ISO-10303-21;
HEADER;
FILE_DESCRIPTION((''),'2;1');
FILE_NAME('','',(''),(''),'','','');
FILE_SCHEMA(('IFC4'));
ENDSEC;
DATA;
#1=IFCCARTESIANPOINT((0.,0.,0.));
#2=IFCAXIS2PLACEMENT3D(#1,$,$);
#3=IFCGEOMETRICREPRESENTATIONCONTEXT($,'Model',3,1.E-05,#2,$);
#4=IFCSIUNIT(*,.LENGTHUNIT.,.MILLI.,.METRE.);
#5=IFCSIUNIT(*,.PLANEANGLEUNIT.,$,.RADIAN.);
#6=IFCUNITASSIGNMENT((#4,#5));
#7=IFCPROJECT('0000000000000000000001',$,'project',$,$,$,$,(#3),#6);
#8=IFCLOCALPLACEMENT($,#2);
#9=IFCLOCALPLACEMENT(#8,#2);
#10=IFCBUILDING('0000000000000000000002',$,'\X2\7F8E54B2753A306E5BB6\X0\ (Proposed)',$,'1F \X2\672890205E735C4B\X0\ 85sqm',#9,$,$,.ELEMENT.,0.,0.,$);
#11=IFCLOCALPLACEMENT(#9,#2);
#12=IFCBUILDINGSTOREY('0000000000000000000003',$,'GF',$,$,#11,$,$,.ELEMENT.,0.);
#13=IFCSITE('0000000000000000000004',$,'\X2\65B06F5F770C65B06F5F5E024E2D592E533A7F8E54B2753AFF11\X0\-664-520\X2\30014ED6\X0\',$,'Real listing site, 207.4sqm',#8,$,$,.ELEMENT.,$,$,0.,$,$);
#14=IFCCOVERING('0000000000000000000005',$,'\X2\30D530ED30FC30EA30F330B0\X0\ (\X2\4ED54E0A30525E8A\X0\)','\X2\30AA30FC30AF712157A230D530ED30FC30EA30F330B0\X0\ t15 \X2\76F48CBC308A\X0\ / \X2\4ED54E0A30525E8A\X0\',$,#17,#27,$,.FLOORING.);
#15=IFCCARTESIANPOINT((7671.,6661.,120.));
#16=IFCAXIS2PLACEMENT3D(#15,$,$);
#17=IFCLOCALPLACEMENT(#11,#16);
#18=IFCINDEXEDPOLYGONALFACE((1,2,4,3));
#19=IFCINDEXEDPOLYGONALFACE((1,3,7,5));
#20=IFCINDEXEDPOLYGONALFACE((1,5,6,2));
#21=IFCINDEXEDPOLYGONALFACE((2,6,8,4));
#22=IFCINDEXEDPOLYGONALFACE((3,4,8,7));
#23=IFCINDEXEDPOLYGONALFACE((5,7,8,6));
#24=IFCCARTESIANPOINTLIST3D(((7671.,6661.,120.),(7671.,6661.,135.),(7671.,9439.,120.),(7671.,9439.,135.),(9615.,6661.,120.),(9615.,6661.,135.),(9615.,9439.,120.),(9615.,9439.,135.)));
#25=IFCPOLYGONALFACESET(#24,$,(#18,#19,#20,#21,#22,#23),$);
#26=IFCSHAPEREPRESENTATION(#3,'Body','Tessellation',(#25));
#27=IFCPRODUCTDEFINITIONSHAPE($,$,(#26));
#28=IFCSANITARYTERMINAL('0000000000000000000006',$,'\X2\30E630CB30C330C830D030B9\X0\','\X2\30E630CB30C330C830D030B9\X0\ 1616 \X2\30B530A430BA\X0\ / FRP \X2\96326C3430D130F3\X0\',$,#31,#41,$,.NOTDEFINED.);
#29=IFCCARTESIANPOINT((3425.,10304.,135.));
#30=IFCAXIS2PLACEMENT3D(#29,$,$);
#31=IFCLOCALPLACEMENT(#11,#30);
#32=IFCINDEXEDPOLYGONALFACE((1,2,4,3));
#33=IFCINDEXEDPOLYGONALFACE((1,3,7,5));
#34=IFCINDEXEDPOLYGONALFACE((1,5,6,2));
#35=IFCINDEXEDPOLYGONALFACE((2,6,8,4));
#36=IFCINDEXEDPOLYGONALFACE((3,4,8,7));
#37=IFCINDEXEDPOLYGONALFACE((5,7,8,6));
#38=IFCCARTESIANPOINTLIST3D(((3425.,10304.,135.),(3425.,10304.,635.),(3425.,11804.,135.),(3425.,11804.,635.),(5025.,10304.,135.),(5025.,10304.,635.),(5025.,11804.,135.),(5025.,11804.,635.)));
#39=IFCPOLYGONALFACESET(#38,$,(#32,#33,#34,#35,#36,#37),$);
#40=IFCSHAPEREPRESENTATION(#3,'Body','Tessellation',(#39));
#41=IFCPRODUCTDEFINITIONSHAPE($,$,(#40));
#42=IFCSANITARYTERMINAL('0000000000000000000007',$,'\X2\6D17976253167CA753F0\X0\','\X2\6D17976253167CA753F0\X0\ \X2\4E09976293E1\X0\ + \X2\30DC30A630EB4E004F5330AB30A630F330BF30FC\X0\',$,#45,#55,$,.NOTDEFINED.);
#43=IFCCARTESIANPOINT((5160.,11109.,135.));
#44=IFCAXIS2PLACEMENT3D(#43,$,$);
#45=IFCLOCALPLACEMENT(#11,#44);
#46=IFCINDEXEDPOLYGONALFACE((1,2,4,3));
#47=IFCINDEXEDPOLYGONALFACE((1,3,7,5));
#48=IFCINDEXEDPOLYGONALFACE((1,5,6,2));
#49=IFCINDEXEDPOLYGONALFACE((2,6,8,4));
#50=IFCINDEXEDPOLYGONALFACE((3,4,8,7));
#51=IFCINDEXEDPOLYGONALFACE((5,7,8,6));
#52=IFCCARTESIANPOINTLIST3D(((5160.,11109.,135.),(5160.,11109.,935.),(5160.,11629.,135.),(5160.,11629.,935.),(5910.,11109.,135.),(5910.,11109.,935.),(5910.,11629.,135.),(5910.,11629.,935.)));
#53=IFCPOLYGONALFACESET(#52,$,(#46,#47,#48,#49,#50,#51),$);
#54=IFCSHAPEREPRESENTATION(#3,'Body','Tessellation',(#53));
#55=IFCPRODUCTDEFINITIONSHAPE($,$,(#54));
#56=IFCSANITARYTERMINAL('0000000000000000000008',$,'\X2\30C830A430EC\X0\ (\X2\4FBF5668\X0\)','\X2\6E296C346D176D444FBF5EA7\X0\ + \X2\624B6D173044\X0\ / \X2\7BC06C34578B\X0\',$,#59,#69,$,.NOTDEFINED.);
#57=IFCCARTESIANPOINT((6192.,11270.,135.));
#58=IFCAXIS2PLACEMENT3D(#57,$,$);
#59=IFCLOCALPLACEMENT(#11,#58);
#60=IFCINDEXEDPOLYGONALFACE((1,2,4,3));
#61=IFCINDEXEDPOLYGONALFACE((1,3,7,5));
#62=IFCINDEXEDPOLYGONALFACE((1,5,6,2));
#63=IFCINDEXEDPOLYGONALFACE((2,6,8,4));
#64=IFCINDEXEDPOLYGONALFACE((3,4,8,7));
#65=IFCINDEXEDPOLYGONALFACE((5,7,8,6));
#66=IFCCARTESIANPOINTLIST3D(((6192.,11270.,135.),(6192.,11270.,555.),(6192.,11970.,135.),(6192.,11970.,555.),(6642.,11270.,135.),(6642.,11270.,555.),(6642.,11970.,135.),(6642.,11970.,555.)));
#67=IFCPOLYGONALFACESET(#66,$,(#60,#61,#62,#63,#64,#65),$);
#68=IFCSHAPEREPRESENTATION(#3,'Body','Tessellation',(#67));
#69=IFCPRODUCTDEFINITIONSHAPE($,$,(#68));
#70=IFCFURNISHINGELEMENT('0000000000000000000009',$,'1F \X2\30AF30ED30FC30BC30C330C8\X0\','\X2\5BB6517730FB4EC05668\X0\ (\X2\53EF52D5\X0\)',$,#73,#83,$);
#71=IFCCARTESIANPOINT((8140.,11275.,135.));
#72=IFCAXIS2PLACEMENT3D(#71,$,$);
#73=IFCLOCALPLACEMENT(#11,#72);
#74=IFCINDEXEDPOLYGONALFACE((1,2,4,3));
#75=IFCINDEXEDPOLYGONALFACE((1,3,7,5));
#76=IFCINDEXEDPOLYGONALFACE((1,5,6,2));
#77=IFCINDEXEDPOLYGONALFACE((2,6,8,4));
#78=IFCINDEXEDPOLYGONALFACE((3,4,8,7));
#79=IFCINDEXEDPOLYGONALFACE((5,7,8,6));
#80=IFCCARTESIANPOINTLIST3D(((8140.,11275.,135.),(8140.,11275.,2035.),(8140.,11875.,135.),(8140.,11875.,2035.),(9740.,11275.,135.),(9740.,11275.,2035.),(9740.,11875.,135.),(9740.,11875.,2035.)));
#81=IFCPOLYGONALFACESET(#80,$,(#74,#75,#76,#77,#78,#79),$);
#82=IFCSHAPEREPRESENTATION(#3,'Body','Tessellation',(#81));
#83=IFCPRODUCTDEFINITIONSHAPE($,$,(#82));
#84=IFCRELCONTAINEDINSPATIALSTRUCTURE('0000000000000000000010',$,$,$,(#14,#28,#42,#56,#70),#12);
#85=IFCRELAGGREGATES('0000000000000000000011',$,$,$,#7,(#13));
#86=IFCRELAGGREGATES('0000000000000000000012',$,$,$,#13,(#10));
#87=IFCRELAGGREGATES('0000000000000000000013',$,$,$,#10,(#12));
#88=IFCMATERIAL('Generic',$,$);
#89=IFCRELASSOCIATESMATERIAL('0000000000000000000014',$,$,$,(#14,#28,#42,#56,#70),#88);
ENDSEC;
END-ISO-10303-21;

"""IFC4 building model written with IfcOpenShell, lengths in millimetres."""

from ifc_helpers import new_model, si_unit, frame, frame_2d, origin, place, context, project, spatial, rectangle, extrude, material, element, save


model = new_model("IFC4")

# Units and contexts
model_context = context("Model", 3, precision=1e-05, world=origin())
ifc_project = project(units=[si_unit("LENGTHUNIT", "METRE", prefix="MILLI"), si_unit("PLANEANGLEUNIT", "RADIAN")], contexts=[model_context])

# Site, building, storey
site_placement = place(None, origin())
site = spatial("IfcSite", under=ifc_project, at=site_placement, Name="新潟県新潟市中央区美咲町１-664-520、他", ObjectType="Real listing site, 207.4sqm", CompositionType="ELEMENT", RefElevation=0.0)
building_placement = place(site_placement, origin())
building = spatial("IfcBuilding", under=site, at=building_placement, Name="美咲町の家 (Proposed)", ObjectType="1F 木造平屋 85sqm", CompositionType="ELEMENT", ElevationOfRefHeight=0.0, ElevationOfTerrain=0.0)
storey_placement = place(building_placement, origin())
storey = spatial("IfcBuildingStorey", under=building, at=storey_placement, Name="GF", CompositionType="ELEMENT", Elevation=0.0)

# Covering
ifc_material_1 = material(Name="Generic")
covering_1_placement = place(storey_placement, frame((7671.0, 6661.0, 120.0)))
element("IfcCovering", 1, at=covering_1_placement, inside=storey, material=ifc_material_1, Name="フローリング (仕上げ床)", Description="オーク無垢フローリング t15 直貼り / 仕上げ床", PredefinedType="FLOORING", context=model_context, shape_type="SweptSolid", body=[
    extrude(rectangle(XDim=1944.0, YDim=2778.0, at=frame_2d((972.0, 1389.0))), frame((7671.0, 6661.0, 120.0)), (0.0, 0.0, 1.0), 15.0),
])

# Sanitary terminals
sanitary_terminal_1_placement = place(storey_placement, frame((3425.0, 10304.0, 135.0)))
element("IfcSanitaryTerminal", 2, at=sanitary_terminal_1_placement, inside=storey, material=ifc_material_1, Name="ユニットバス", Description="ユニットバス 1616 サイズ / FRP 防水パン", PredefinedType="NOTDEFINED", context=model_context, shape_type="SweptSolid", body=[
    extrude(rectangle(XDim=1600.0, YDim=1500.0, at=frame_2d((800.0, 750.0))), frame((3425.0, 10304.0, 135.0)), (0.0, 0.0, 1.0), 500.0),
])
sanitary_terminal_2_placement = place(storey_placement, frame((5160.0, 11109.0, 135.0)))
element("IfcSanitaryTerminal", 3, at=sanitary_terminal_2_placement, inside=storey, material=ifc_material_1, Name="洗面化粧台", Description="洗面化粧台 三面鏡 + ボウル一体カウンター", PredefinedType="NOTDEFINED", context=model_context, shape_type="SweptSolid", body=[
    extrude(rectangle(XDim=750.0, YDim=520.0, at=frame_2d((375.0, 260.0))), frame((5160.0, 11109.0, 135.0)), (0.0, 0.0, 1.0), 800.0),
])
sanitary_terminal_3_placement = place(storey_placement, frame((6192.0, 11270.0, 135.0)))
element("IfcSanitaryTerminal", 4, at=sanitary_terminal_3_placement, inside=storey, material=ifc_material_1, Name="トイレ (便器)", Description="温水洗浄便座 + 手洗い / 節水型", PredefinedType="NOTDEFINED", context=model_context, shape_type="SweptSolid", body=[
    extrude(rectangle(XDim=450.0, YDim=700.0, at=frame_2d((225.0, 350.0))), frame((6192.0, 11270.0, 135.0)), (0.0, 0.0, 1.0), 420.0),
])

# Furnishing element
furnishing_placement = place(storey_placement, frame((8140.0, 11275.0, 135.0)))
element("IfcFurnishingElement", 5, at=furnishing_placement, inside=storey, material=ifc_material_1, Name="1F クローゼット", Description="家具・什器 (可動)", context=model_context, shape_type="SweptSolid", body=[
    extrude(rectangle(XDim=1600.0, YDim=600.0, at=frame_2d((800.0, 300.0))), frame((8140.0, 11275.0, 135.0)), (0.0, 0.0, 1.0), 1900.0),
])

save(model, "model.ifc")
